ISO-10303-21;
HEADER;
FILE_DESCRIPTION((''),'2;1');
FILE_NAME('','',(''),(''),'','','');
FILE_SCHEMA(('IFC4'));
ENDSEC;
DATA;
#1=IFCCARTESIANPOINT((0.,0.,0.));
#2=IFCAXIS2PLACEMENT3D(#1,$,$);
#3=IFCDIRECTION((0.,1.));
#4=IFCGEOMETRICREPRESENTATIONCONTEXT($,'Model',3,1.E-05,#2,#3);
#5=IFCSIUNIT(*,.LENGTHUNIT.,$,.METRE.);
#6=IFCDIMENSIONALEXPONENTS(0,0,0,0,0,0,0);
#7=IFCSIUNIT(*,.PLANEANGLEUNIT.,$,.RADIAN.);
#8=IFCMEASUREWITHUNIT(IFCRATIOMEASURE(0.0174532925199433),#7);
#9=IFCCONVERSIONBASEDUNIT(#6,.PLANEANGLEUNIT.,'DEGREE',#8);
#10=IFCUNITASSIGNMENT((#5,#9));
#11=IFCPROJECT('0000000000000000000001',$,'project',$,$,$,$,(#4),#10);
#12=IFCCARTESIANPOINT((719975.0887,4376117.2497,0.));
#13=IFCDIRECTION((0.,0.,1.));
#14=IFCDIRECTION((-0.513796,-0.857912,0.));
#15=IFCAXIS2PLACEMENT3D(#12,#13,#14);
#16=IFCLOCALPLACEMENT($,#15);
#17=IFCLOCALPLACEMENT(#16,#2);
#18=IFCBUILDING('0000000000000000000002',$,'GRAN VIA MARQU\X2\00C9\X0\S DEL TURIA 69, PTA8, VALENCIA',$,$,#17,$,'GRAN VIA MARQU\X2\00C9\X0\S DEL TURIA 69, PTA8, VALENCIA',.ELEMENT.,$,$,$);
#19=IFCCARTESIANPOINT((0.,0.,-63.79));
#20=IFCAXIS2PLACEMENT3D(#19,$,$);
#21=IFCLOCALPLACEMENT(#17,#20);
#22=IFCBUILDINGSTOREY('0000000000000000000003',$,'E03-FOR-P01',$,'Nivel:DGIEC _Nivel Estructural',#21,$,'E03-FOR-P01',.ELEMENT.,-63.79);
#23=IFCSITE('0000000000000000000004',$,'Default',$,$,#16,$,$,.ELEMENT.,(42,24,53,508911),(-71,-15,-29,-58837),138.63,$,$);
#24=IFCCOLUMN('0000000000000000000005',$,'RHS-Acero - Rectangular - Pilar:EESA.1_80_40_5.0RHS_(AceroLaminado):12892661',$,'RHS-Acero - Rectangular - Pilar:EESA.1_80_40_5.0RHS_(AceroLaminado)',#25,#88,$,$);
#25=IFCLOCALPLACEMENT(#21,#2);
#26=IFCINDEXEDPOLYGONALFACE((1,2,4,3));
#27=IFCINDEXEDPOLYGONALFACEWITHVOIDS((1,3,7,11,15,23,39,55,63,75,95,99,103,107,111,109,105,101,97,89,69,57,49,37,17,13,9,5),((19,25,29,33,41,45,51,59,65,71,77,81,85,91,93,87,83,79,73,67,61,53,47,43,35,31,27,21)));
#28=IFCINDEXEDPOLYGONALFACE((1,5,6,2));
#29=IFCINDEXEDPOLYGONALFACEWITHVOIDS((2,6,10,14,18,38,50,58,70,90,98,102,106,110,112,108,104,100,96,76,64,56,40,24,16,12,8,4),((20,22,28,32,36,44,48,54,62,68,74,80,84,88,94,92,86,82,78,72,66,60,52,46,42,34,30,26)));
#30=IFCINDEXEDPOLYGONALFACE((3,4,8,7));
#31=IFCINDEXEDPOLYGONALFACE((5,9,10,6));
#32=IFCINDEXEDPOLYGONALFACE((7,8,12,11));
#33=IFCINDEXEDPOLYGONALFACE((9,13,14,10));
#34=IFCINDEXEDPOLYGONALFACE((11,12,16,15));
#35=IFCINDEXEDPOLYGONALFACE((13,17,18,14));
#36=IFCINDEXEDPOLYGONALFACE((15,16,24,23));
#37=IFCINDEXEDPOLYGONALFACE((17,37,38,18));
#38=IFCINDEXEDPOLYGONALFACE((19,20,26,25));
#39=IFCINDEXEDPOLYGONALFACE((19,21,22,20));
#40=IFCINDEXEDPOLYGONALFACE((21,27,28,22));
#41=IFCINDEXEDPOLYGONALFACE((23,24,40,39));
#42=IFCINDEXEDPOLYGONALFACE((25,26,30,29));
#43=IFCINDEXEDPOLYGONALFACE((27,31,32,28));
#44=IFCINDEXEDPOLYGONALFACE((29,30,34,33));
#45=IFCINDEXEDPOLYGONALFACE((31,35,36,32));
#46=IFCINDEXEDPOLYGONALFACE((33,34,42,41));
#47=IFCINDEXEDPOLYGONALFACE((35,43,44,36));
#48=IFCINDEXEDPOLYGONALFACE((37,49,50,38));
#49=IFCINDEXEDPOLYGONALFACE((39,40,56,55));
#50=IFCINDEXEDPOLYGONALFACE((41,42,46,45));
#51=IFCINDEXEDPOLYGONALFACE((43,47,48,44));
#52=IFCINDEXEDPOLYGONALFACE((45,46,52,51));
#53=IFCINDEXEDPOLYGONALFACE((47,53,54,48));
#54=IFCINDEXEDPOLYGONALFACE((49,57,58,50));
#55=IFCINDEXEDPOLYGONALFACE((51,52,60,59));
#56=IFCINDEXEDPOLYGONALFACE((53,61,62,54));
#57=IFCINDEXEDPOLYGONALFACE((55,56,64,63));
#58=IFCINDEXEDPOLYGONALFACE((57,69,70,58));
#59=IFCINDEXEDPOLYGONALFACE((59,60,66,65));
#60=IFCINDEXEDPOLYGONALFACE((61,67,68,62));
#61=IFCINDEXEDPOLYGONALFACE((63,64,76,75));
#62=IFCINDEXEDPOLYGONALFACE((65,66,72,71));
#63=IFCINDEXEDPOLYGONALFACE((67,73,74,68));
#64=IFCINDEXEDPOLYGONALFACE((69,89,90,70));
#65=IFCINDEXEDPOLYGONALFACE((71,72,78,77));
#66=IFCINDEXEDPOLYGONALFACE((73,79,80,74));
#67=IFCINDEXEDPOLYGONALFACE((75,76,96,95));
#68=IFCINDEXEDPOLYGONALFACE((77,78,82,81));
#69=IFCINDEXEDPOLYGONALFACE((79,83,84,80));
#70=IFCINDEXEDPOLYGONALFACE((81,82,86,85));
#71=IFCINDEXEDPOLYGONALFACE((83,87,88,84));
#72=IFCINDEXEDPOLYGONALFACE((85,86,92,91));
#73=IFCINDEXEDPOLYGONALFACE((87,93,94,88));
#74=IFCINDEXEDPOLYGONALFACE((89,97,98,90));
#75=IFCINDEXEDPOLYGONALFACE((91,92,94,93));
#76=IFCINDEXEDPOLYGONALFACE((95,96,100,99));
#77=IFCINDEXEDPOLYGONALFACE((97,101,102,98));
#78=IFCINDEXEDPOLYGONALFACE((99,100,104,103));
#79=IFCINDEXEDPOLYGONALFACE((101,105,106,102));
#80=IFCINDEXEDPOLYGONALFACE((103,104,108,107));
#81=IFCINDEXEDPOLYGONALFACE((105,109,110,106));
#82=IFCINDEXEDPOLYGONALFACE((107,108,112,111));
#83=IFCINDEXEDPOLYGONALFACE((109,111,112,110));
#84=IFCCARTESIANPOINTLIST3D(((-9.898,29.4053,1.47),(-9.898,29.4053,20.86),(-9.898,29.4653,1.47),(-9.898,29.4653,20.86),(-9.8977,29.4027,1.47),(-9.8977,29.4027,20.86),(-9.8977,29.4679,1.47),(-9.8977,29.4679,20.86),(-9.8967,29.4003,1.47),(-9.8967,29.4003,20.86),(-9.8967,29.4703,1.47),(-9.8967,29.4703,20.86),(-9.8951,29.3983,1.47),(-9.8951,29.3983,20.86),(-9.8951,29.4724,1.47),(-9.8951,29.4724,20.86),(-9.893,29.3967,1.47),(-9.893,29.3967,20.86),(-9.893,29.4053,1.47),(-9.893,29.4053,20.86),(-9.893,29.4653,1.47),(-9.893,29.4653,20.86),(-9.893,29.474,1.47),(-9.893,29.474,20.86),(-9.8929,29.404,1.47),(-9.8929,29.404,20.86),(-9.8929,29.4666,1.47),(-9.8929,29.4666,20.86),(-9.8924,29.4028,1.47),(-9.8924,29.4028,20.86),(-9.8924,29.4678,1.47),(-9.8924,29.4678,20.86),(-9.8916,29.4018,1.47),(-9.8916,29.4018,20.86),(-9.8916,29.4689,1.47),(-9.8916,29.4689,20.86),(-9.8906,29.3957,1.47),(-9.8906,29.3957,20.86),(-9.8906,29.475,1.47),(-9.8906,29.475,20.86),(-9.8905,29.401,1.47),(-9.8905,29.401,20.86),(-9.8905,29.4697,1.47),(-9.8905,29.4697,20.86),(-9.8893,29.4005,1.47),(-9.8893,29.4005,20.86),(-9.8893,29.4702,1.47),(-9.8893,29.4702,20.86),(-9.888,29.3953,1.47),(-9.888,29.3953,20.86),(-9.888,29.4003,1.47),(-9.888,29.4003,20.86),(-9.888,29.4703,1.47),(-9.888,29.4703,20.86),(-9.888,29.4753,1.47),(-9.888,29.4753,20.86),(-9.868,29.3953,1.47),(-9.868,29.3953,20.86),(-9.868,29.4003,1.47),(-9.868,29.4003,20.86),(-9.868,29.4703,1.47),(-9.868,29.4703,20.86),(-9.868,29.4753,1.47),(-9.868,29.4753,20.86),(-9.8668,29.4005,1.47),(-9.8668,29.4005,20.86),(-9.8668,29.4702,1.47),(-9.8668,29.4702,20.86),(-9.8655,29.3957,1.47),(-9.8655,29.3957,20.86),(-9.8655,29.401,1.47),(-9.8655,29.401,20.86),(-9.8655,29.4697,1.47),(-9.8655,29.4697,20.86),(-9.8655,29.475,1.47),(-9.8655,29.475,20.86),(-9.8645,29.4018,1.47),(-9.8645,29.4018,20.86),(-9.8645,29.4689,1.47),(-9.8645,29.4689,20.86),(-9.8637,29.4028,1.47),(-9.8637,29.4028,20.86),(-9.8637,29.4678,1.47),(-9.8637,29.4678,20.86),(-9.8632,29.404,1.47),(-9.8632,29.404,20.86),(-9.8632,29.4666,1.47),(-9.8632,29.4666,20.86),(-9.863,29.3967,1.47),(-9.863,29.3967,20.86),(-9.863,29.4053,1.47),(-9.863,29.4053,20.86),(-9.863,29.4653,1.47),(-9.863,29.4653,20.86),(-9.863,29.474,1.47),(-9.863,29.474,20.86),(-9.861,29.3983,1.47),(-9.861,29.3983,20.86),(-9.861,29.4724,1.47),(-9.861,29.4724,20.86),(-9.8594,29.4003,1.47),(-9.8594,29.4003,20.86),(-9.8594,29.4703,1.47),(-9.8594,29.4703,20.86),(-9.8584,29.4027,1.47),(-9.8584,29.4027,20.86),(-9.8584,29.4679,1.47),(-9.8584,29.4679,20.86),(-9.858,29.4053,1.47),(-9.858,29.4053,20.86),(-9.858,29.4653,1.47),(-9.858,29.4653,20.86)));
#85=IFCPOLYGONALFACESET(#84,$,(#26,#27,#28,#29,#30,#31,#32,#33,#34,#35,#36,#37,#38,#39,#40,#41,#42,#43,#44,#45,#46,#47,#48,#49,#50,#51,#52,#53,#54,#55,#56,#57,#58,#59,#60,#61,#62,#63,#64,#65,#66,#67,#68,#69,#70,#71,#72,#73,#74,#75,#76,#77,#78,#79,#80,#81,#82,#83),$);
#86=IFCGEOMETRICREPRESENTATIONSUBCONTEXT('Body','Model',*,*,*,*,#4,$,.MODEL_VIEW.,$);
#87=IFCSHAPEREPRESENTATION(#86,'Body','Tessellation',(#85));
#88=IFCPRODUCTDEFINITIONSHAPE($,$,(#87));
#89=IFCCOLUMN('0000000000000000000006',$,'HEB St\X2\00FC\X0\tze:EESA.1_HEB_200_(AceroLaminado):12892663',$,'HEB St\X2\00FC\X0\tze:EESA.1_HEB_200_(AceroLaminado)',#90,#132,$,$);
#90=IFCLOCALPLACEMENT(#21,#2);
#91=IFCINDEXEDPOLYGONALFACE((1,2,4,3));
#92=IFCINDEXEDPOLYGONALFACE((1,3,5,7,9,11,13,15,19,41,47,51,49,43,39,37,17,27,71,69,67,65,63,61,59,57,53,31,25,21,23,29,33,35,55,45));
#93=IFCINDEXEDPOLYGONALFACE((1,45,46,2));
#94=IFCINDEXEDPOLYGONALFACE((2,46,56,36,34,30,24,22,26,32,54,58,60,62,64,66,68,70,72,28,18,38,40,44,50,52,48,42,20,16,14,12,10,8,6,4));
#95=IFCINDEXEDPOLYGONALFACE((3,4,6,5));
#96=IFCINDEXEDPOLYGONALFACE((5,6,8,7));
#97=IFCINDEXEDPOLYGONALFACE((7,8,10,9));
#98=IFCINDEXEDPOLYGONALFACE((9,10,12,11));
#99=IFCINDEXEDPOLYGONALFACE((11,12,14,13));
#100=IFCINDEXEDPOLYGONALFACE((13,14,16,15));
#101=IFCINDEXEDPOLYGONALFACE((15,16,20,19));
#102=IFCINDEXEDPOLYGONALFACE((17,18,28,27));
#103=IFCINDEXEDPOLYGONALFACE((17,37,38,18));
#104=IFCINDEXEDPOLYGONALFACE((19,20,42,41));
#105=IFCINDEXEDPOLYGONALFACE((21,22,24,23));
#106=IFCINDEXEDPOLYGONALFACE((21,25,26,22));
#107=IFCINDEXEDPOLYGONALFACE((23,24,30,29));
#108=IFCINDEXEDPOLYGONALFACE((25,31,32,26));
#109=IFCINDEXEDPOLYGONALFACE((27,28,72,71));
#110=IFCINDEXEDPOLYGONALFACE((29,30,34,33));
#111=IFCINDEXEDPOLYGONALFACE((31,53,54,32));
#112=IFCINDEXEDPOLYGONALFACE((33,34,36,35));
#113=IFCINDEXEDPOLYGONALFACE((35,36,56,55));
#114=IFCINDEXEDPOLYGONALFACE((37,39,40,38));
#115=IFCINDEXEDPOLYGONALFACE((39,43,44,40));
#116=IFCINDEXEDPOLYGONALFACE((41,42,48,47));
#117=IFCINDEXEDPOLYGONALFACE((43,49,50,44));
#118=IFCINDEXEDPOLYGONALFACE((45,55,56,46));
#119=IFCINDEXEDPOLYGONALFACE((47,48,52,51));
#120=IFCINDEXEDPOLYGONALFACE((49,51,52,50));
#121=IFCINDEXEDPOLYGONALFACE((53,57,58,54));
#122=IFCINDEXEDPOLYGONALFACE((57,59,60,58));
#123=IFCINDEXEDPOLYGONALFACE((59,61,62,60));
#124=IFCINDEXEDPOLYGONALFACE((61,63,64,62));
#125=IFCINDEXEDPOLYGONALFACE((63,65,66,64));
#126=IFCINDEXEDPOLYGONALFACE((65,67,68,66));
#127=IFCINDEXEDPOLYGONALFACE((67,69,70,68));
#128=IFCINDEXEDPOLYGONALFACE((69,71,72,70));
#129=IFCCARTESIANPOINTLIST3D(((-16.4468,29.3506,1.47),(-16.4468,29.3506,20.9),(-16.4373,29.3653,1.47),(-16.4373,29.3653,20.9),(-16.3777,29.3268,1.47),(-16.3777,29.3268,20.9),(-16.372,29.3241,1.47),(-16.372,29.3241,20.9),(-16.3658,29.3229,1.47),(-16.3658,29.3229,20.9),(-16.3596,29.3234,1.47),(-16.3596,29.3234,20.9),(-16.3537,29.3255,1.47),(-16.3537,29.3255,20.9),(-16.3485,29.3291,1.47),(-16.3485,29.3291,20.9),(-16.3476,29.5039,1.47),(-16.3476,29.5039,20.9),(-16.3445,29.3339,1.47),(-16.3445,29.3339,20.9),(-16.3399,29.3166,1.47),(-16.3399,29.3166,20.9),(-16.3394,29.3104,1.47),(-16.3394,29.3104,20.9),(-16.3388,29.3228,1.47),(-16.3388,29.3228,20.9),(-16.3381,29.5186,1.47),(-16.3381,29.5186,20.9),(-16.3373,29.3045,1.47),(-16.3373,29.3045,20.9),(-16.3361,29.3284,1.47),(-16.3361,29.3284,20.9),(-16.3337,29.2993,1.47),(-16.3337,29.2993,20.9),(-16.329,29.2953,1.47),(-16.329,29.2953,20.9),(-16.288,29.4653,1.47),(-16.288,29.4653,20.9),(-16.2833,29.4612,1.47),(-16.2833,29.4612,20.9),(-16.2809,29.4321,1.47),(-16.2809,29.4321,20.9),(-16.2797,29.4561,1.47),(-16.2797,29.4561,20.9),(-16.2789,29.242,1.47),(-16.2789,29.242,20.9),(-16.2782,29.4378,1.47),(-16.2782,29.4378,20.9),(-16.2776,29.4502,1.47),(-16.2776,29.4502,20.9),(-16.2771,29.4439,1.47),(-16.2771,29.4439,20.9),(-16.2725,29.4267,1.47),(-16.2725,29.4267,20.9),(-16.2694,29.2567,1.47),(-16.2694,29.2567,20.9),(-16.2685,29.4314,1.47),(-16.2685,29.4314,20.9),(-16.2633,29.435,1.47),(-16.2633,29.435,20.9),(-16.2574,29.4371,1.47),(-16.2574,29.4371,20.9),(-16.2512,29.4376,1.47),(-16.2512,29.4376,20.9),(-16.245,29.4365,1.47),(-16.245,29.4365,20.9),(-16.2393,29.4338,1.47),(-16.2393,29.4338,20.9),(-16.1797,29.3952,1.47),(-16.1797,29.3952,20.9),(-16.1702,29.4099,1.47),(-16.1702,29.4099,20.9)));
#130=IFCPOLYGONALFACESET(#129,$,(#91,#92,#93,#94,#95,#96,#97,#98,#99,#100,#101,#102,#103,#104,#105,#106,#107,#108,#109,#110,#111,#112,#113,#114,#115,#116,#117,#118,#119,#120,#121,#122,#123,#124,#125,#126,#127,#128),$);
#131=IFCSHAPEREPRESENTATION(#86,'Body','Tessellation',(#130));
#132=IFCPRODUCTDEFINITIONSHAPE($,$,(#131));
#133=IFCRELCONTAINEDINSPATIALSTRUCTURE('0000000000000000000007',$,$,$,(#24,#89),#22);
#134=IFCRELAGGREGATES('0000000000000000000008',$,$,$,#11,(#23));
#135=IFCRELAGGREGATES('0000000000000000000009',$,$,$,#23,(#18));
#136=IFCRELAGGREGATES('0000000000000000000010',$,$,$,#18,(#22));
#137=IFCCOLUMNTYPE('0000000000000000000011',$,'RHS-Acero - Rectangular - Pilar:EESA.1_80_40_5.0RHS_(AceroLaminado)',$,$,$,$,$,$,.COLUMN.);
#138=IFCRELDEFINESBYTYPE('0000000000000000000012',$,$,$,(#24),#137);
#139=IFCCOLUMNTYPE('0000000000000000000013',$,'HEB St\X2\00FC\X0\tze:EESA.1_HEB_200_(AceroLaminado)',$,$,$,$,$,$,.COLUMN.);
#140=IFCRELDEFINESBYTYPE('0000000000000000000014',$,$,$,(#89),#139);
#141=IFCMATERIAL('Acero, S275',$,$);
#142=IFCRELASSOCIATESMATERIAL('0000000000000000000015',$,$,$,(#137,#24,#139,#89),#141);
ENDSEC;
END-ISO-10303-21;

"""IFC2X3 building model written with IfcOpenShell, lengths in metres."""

from ifc_helpers import new_model, entity, si_unit, converted_unit, direction, frame, frame_2d, origin, place, context, subcontext, project, spatial, polyline, circle_curve, parameter, trimmed, segment, composite_curve, outline, extrude, source, transform, mapped, material, type_object, type_shapes, element, save


model = new_model("IFC2X3")

# Units and contexts
model_context = context("Model", 3, precision=1e-05, world=origin(), true_north=direction((0.0, 1.0)))
body_context = subcontext(model_context, "Body", "Model", "MODEL_VIEW")
ifc_project = project(units=[si_unit("LENGTHUNIT", "METRE"), converted_unit("PLANEANGLEUNIT", "DEGREE", entity("IfcRatioMeasure", 0.0174532925199433), si_unit("PLANEANGLEUNIT", "RADIAN"), dimensions=[0, 0, 0, 0, 0, 0, 0])], contexts=[model_context])

# Site, building, storey
site_placement = place(None, frame((719975.0887, 4376117.2497, 0.0), z_axis=(0.0, 0.0, 1.0), x_axis=(-0.513796, -0.857912, 0.0)))
site = spatial("IfcSite", under=ifc_project, at=site_placement, Name="Default", CompositionType="ELEMENT", RefLatitude=(42, 24, 53, 508911), RefLongitude=(-71, -15, -29, -58837), RefElevation=138.63)
building_placement = place(site_placement, origin())
building = spatial("IfcBuilding", under=site, at=building_placement, Name="GRAN VIA MARQUÉS DEL TURIA 69, PTA8, VALENCIA", LongName="GRAN VIA MARQUÉS DEL TURIA 69, PTA8, VALENCIA", CompositionType="ELEMENT")
storey_placement = place(building_placement, frame((0.0, 0.0, -63.79)))
storey = spatial("IfcBuildingStorey", under=building, at=storey_placement, Name="E03-FOR-P01", ObjectType="Nivel:DGIEC _Nivel Estructural", LongName="E03-FOR-P01", CompositionType="ELEMENT", Elevation=-63.79)

# Columns
ifc_material_1 = material(Name="Acero, S275")
column_type_1 = type_object("IfcColumnType", Name="RHS-Acero - Rectangular - Pilar:EESA.1_80_40_5.0RHS_(AceroLaminado)", PredefinedType="COLUMN", material=ifc_material_1)
shared_shape_1 = source(origin(), body_context, "Body", "SweptSolid", [
    extrude(outline(composite_curve([segment(polyline([(-0.01, -0.04), (0.01, -0.04)]), True, "CONTINUOUS"), segment(trimmed(circle_curve(frame_2d((0.01, -0.03), x_axis=(-1.0, 0.0)), 0.01), [parameter(90.0)], [parameter(180.0)], True, "PARAMETER"), True, "CONTINUOUS"), segment(polyline([(0.02, -0.03), (0.02, 0.03)]), True, "CONTINUOUS"), segment(trimmed(circle_curve(frame_2d((0.01, 0.03), x_axis=(-1.0, 0.0)), 0.01), [parameter(180.0)], [parameter(270.0)], True, "PARAMETER"), True, "CONTINUOUS"), segment(polyline([(0.01, 0.04), (-0.01, 0.04)]), True, "CONTINUOUS"), segment(trimmed(circle_curve(frame_2d((-0.01, 0.03), x_axis=(-1.0, 0.0)), 0.01), [parameter(270.0)], [parameter(360.0)], True, "PARAMETER"), True, "CONTINUOUS"), segment(polyline([(-0.02, 0.03), (-0.02, -0.03)]), True, "CONTINUOUS"), segment(trimmed(circle_curve(frame_2d((-0.01, -0.03), x_axis=(-1.0, 0.0)), 0.01), [parameter(360.0)], [parameter(90.0)], True, "PARAMETER"), True, "CONTINUOUS")], self_intersect=False), holes=[composite_curve([segment(trimmed(circle_curve(frame_2d((-0.01, -0.03), x_axis=(-1.0, 0.0)), 0.005), [parameter(0.0)], [parameter(90.0)], True, "PARAMETER"), False, "CONTINUOUS"), segment(polyline([(-0.015, -0.03), (-0.015, 0.03)]), True, "CONTINUOUS"), segment(trimmed(circle_curve(frame_2d((-0.01, 0.03), x_axis=(-1.0, 0.0)), 0.005), [parameter(270.0)], [parameter(0.0)], True, "PARAMETER"), False, "CONTINUOUS"), segment(polyline([(-0.01, 0.035), (0.01, 0.035)]), True, "CONTINUOUS"), segment(trimmed(circle_curve(frame_2d((0.01, 0.03), x_axis=(-1.0, 0.0)), 0.005), [parameter(180.0)], [parameter(270.0)], True, "PARAMETER"), False, "CONTINUOUS"), segment(polyline([(0.015, 0.03), (0.015, -0.03)]), True, "CONTINUOUS"), segment(trimmed(circle_curve(frame_2d((0.01, -0.03), x_axis=(-1.0, 0.0)), 0.005), [parameter(90.0)], [parameter(180.0)], True, "PARAMETER"), False, "CONTINUOUS"), segment(polyline([(0.01, -0.035), (-0.01, -0.035)]), True, "CONTINUOUS")], self_intersect=False)]), frame((0.0, 0.0, -62.32), z_axis=(0.0, 0.0, 1.0), x_axis=(-1.0, 0.0, 0.0)), (0.0, 0.0, 1.0), 19.39),
])
type_shapes(column_type_1, [shared_shape_1])
for number, where, z_axis, x_axis, name in (
    (1, (-9.878, 29.4353, 63.79), (0.0, 0.0, 1.0), (-1.0, 0.0, 0.0), "RHS-Acero - Rectangular - Pilar:EESA.1_80_40_5.0RHS_(AceroLaminado):12892661"),
):
    element("IfcColumn", number, at=place(storey_placement, frame(where, z_axis=z_axis, x_axis=x_axis)), inside=storey, type_object=column_type_1, material=ifc_material_1, Name=name, ObjectType="RHS-Acero - Rectangular - Pilar:EESA.1_80_40_5.0RHS_(AceroLaminado)", context=body_context, shape_type="MappedRepresentation", body=[
        mapped(shared_shape_1, transform((0.0, 0.0, 0.0), scale=1.0)),
    ])
column_type_2 = type_object("IfcColumnType", Name="HEB Stütze:EESA.1_HEB_200_(AceroLaminado)", PredefinedType="COLUMN", material=ifc_material_1)
shared_shape_2 = source(origin(), body_context, "Body", "SweptSolid", [
    extrude(outline(composite_curve([segment(polyline([(0.0825, -0.1), (0.1, -0.1)]), True, "CONTINUOUS"), segment(polyline([(0.1, -0.1), (0.1, 0.1)]), True, "CONTINUOUS"), segment(polyline([(0.1, 0.1), (0.0825, 0.1)]), True, "CONTINUOUS"), segment(polyline([(0.0825, 0.1), (0.0825, 0.029)]), True, "CONTINUOUS"), segment(trimmed(circle_curve(frame_2d((0.0585, 0.029), x_axis=(1.0, 0.0)), 0.024), [parameter(270.0)], [parameter(0.0)], True, "PARAMETER"), False, "CONTINUOUS"), segment(polyline([(0.0585, 0.005), (-0.0585, 0.005)]), True, "CONTINUOUS"), segment(trimmed(circle_curve(frame_2d((-0.0585, 0.029), x_axis=(0.0, -1.0)), 0.024), [parameter(270.0)], [parameter(0.0)], True, "PARAMETER"), False, "CONTINUOUS"), segment(polyline([(-0.0825, 0.029), (-0.0825, 0.1)]), True, "CONTINUOUS"), segment(polyline([(-0.0825, 0.1), (-0.1, 0.1)]), True, "CONTINUOUS"), segment(polyline([(-0.1, 0.1), (-0.1, -0.1)]), True, "CONTINUOUS"), segment(polyline([(-0.1, -0.1), (-0.0825, -0.1)]), True, "CONTINUOUS"), segment(polyline([(-0.0825, -0.1), (-0.0825, -0.029)]), True, "CONTINUOUS"), segment(trimmed(circle_curve(frame_2d((-0.0585, -0.029), x_axis=(-1.0, 0.0)), 0.024), [parameter(270.0)], [parameter(0.0)], True, "PARAMETER"), False, "CONTINUOUS"), segment(polyline([(-0.0585, -0.005), (0.0585, -0.005)]), True, "CONTINUOUS"), segment(trimmed(circle_curve(frame_2d((0.0585, -0.029), x_axis=(0.0, 1.0)), 0.024), [parameter(270.0)], [parameter(0.0)], True, "PARAMETER"), False, "CONTINUOUS"), segment(polyline([(0.0825, -0.029), (0.0825, -0.1)]), True, "CONTINUOUS")], self_intersect=False)), frame((0.0, 0.0, -62.32), z_axis=(0.0, 0.0, 1.0), x_axis=(0.0, -1.0, 0.0)), (0.0, 0.0, 1.0), 19.43),
])
type_shapes(column_type_2, [shared_shape_2])
column_1_placement = place(storey_placement, frame((-16.3085, 29.3803, 63.79), z_axis=(0.0, 0.0, 1.0), x_axis=(0.839602, -0.543202, 0.0)))
element("IfcColumn", 2, at=column_1_placement, inside=storey, type_object=column_type_2, material=ifc_material_1, Name="HEB Stütze:EESA.1_HEB_200_(AceroLaminado):12892663", ObjectType="HEB Stütze:EESA.1_HEB_200_(AceroLaminado)", context=body_context, shape_type="MappedRepresentation", body=[
    mapped(shared_shape_2, transform((0.0, 0.0, 0.0), scale=1.0)),
])

save(model, "model.ifc")
